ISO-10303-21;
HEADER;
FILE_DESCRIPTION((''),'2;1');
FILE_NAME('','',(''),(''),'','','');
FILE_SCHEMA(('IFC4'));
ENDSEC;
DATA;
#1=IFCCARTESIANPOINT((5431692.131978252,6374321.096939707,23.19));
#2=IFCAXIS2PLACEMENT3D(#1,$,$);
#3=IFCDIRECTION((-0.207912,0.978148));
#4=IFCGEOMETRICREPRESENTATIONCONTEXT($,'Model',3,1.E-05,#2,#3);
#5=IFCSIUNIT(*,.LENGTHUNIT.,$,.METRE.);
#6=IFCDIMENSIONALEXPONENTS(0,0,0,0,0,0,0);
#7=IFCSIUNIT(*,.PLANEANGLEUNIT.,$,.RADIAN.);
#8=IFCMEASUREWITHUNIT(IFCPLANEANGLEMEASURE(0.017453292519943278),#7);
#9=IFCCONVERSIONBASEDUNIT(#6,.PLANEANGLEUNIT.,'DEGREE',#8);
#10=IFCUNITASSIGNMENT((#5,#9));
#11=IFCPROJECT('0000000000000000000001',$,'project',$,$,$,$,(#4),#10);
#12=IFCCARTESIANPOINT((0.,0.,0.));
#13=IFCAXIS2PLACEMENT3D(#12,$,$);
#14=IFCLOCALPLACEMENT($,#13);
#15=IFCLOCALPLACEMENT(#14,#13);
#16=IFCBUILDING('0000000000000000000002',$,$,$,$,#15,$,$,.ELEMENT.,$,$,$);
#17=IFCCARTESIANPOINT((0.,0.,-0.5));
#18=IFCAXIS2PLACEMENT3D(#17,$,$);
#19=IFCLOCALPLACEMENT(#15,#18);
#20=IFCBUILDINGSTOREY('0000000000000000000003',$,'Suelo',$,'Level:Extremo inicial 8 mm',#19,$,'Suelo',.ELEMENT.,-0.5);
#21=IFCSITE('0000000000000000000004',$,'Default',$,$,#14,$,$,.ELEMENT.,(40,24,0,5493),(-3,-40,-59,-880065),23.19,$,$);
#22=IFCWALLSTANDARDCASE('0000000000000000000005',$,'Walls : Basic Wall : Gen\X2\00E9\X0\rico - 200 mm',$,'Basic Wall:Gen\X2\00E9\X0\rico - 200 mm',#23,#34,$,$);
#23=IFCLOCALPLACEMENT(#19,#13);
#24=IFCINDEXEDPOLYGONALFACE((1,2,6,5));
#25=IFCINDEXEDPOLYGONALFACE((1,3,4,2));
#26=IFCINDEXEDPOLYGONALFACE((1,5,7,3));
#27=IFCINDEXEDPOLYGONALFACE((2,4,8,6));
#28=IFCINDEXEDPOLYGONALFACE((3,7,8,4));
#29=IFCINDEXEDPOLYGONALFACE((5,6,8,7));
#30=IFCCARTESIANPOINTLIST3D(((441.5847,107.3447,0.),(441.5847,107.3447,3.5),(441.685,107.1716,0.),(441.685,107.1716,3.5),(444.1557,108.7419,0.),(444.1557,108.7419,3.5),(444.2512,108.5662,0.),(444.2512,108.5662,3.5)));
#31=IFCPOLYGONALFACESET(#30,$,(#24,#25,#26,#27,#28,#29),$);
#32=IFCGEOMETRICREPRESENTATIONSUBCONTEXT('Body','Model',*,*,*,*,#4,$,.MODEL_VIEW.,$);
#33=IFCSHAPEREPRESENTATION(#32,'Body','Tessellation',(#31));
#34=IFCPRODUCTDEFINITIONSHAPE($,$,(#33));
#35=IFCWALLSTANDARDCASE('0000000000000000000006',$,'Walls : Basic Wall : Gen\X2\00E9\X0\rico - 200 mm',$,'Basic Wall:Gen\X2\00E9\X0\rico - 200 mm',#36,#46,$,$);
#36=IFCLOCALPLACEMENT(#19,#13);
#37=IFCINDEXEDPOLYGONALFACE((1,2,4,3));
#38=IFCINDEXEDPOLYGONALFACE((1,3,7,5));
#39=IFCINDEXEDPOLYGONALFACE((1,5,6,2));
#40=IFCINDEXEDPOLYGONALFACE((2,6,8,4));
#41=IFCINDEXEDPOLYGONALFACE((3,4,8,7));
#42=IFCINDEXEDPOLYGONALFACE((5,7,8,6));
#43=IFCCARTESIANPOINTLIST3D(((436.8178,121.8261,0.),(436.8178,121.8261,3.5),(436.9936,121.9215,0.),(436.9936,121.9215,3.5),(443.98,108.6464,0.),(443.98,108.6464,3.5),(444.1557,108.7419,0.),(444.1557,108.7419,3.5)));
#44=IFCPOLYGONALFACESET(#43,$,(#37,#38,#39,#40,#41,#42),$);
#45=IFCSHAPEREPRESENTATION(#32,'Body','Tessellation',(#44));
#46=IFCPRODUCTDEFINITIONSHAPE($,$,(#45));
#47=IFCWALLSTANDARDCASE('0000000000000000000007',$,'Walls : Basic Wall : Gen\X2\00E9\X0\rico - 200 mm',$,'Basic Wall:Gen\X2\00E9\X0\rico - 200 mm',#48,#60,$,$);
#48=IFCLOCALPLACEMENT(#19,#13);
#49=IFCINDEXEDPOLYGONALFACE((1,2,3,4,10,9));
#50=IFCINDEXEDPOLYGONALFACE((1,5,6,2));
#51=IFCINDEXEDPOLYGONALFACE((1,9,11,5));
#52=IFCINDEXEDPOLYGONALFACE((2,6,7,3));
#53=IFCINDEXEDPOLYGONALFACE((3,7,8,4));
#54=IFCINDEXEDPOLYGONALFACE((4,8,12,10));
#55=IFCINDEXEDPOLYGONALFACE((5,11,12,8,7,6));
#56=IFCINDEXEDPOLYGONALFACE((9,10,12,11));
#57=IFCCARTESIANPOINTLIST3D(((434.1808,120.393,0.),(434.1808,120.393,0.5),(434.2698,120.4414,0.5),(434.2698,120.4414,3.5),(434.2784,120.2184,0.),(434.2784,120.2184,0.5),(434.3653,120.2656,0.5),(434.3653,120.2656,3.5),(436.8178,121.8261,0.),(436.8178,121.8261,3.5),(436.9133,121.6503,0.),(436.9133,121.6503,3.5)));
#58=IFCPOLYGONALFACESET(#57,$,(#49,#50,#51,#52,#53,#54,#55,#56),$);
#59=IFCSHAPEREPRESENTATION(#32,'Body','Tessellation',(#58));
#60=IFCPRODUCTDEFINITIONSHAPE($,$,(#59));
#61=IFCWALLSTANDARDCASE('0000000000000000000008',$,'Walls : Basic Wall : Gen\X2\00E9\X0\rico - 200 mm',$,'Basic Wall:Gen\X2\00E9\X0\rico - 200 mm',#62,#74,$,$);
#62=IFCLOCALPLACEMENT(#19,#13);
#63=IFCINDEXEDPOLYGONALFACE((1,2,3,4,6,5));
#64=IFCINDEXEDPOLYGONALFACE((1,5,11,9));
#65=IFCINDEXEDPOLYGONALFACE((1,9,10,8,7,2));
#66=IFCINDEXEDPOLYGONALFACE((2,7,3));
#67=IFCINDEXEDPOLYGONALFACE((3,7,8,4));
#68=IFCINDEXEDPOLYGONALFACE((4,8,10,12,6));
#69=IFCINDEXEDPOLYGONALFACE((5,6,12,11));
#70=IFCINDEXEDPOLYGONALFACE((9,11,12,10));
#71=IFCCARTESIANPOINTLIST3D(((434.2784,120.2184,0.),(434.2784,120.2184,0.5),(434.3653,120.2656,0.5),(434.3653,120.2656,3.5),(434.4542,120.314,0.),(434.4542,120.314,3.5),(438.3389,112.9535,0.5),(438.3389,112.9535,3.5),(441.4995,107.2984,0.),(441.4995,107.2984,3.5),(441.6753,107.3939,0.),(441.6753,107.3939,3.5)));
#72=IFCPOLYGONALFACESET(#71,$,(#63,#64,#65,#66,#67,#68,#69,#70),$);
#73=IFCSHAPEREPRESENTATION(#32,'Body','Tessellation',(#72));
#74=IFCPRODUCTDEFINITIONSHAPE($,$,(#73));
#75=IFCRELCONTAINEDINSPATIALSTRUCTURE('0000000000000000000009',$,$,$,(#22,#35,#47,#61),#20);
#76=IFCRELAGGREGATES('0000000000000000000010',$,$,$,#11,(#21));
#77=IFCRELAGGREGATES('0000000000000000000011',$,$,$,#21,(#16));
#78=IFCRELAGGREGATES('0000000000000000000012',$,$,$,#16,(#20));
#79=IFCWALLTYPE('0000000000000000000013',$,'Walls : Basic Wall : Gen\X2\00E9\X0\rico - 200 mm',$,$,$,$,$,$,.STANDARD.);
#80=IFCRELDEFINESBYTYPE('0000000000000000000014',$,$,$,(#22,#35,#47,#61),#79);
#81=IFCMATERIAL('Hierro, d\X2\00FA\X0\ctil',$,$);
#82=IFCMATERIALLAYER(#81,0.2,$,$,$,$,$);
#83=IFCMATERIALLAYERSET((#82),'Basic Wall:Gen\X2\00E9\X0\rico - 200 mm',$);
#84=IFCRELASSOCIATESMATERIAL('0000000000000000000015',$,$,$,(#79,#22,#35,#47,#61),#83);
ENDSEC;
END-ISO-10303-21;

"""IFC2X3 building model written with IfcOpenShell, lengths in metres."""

from ifc_helpers import new_model, entity, si_unit, converted_unit, direction, frame, frame_2d, origin, place, context, subcontext, project, spatial, polyline, rectangle, outline, extrude, clip, bounded_halfspace, material, layer, layer_set, layer_usage, type_object, element, save


model = new_model("IFC2X3")

# Units and contexts
model_context = context("Model", 3, precision=1e-05, world=frame((5431692.131978252, 6374321.096939707, 23.19)), true_north=direction((-0.207912, 0.978148)))
body_context = subcontext(model_context, "Body", "Model", "MODEL_VIEW")
ifc_project = project(units=[si_unit("LENGTHUNIT", "METRE"), converted_unit("PLANEANGLEUNIT", "DEGREE", entity("IfcPlaneAngleMeasure", 0.017453292519943278), si_unit("PLANEANGLEUNIT", "RADIAN"), dimensions=[0, 0, 0, 0, 0, 0, 0])], contexts=[model_context])

# Site, building, storey
site_placement = place(None, origin())
site = spatial("IfcSite", under=ifc_project, at=site_placement, Name="Default", CompositionType="ELEMENT", RefLatitude=(40, 24, 0, 5493), RefLongitude=(-3, -40, -59, -880065), RefElevation=23.19)
building_placement = place(site_placement, origin())
building = spatial("IfcBuilding", under=site, at=building_placement, CompositionType="ELEMENT")
storey_placement = place(building_placement, frame((0.0, 0.0, -0.5)))
storey = spatial("IfcBuildingStorey", under=building, at=storey_placement, Name="Suelo", ObjectType="Level:Extremo inicial 8 mm", LongName="Suelo", CompositionType="ELEMENT", Elevation=-0.5)

# Shared definitions
ifc_material_1 = material(Name="Hierro, dúctil")
ifc_layer_1 = layer(ifc_material_1, 0.2)
ifc_layer_set_1 = layer_set([ifc_layer_1], Name="Basic Wall:Genérico - 200 mm")
wall_type = type_object("IfcWallType", Name="Walls : Basic Wall : Genérico - 200 mm", PredefinedType="STANDARD", material=ifc_layer_set_1)

# Walls
ifc_layer_usage_1 = layer_usage(ifc_layer_set_1, "AXIS2", "NEGATIVE", 0.1)
wall_1_placement = place(storey_placement, frame((441.6324, 107.2569, 0.0), z_axis=(0.0, 0.0, 1.0), x_axis=(0.878643, 0.47748, 0.0)))
element("IfcWallStandardCase", 1, at=wall_1_placement, inside=storey, type_object=wall_type, material=ifc_layer_usage_1, Name="Walls : Basic Wall : Genérico - 200 mm", ObjectType="Basic Wall:Genérico - 200 mm", context=body_context, shape_type="Clipping", body=[
    clip(extrude(outline(polyline([(2.9262, -0.1), (2.9262, 0.1), (2.7262, 0.1), (0.1031, 0.1), (0.0, 0.1), (0.0055, -0.1), (2.9262, -0.1)])), origin(), (0.0, 0.0, 1.0), 3.5), bounded_halfspace(frame((0.0055, -0.1, 3.5), z_axis=(0.0, 0.0, 1.0), x_axis=(0.878643, -0.47748, 0.0)), False, frame((0.0055, -0.1, 3.5)), polyline([(0.0, 0.0), (2.9207, 0.0), (2.9207, 0.2), (2.7207, 0.2), (0.0976, 0.2), (-0.0055, 0.2), (0.0, 0.0)]))),
])
ifc_layer_usage_2 = layer_usage(ifc_layer_set_1, "AXIS2", "NEGATIVE", 0.1)
wall_2_placement = place(storey_placement, frame((444.0679, 108.6942, 0.0), z_axis=(0.0, 0.0, 1.0), x_axis=(-0.47748, 0.878643, 0.0)))
element("IfcWallStandardCase", 2, at=wall_2_placement, inside=storey, type_object=wall_type, material=ifc_layer_usage_2, Name="Walls : Basic Wall : Genérico - 200 mm", ObjectType="Basic Wall:Genérico - 200 mm", context=body_context, shape_type="Clipping", body=[
    clip(extrude(rectangle(XDim=15.0, YDim=0.2, at=frame_2d((7.5, 0.0), x_axis=(-1.0, 0.0))), origin(), (0.0, 0.0, 1.0), 3.5), bounded_halfspace(frame((0.0, -0.1, 3.5), z_axis=(0.0, 0.0, 1.0), x_axis=(-0.47748, -0.878643, 0.0)), False, frame((0.0, -0.1, 3.5)), polyline([(0.0, 0.0), (15.0, 0.0), (15.0, 0.2), (14.8, 0.2), (0.0, 0.2), (0.0, 0.0)]))),
])
ifc_layer_usage_3 = layer_usage(ifc_layer_set_1, "AXIS2", "NEGATIVE", 0.1)
wall_3_placement = place(storey_placement, frame((436.8656, 121.7382, 0.0), z_axis=(0.0, 0.0, 1.0), x_axis=(-0.878643, -0.47748, 0.0)))
element("IfcWallStandardCase", 3, at=wall_3_placement, inside=storey, type_object=wall_type, material=ifc_layer_usage_3, Name="Walls : Basic Wall : Genérico - 200 mm", ObjectType="Basic Wall:Genérico - 200 mm", context=body_context, shape_type="Clipping", body=[
    clip(clip(extrude(outline(polyline([(3.0012, -0.1), (2.9988, 0.1), (2.7988, 0.1), (0.0, 0.1), (0.0, -0.1), (3.0012, -0.1)])), origin(), (0.0, 0.0, 1.0), 3.5), bounded_halfspace(frame((0.0, -0.1, 3.5), z_axis=(0.0, 0.0, 1.0), x_axis=(-0.878643, 0.47748, 0.0)), False, frame((0.0, -0.1, 3.5)), polyline([(0.0, 0.0), (2.9, 0.0), (2.9, 0.2), (2.7988, 0.2), (0.0, 0.2), (0.0, 0.0)]))), bounded_halfspace(frame((2.9, -0.1, 0.5), z_axis=(0.0, 0.0, 1.0), x_axis=(0.0, 1.0, 0.0)), False, frame((2.9, -0.1, 0.5)), polyline([(0.0, 0.0), (0.1012, 0.0), (0.0988, 0.2), (0.0, 0.2), (0.0, 0.0)]))),
])
ifc_layer_usage_4 = layer_usage(ifc_layer_set_1, "AXIS2", "NEGATIVE", 0.1)
wall_4_placement = place(storey_placement, frame((434.3657, 120.2672, 0.0), z_axis=(0.0, 0.0, 1.0), x_axis=(0.487879, -0.872911, 0.0)))
element("IfcWallStandardCase", 4, at=wall_4_placement, inside=storey, type_object=wall_type, material=ifc_layer_usage_4, Name="Walls : Basic Wall : Genérico - 200 mm", ObjectType="Basic Wall:Genérico - 200 mm", context=body_context, shape_type="Clipping", body=[
    clip(clip(extrude(outline(polyline([(14.801, -0.1), (14.8022, -0.0031), (14.8034, 0.1), (0.0024, 0.1), (0.0, -0.1), (14.801, -0.1)])), origin(), (0.0, 0.0, 1.0), 3.5), bounded_halfspace(frame((8.3226, -0.1, 3.5), z_axis=(0.0, 0.0, 1.0), x_axis=(0.487879, 0.872911, 0.0)), False, frame((8.3226, -0.1, 3.5)), polyline([(0.0, 0.0), (6.4784, 0.0), (6.4796, 0.0969), (6.4808, 0.2), (-8.3203, 0.2), (-8.3215, 0.0988), (0.0, 0.0)]))), bounded_halfspace(frame((0.0, -0.1, 0.5), z_axis=(0.0, 0.0, 1.0), x_axis=(0.0, 1.0, 0.0)), False, frame((0.0, -0.1, 0.5)), polyline([(0.0, 0.0), (8.3226, 0.0), (0.0012, 0.0988), (0.0, 0.0)]))),
])

save(model, "model.ifc")
